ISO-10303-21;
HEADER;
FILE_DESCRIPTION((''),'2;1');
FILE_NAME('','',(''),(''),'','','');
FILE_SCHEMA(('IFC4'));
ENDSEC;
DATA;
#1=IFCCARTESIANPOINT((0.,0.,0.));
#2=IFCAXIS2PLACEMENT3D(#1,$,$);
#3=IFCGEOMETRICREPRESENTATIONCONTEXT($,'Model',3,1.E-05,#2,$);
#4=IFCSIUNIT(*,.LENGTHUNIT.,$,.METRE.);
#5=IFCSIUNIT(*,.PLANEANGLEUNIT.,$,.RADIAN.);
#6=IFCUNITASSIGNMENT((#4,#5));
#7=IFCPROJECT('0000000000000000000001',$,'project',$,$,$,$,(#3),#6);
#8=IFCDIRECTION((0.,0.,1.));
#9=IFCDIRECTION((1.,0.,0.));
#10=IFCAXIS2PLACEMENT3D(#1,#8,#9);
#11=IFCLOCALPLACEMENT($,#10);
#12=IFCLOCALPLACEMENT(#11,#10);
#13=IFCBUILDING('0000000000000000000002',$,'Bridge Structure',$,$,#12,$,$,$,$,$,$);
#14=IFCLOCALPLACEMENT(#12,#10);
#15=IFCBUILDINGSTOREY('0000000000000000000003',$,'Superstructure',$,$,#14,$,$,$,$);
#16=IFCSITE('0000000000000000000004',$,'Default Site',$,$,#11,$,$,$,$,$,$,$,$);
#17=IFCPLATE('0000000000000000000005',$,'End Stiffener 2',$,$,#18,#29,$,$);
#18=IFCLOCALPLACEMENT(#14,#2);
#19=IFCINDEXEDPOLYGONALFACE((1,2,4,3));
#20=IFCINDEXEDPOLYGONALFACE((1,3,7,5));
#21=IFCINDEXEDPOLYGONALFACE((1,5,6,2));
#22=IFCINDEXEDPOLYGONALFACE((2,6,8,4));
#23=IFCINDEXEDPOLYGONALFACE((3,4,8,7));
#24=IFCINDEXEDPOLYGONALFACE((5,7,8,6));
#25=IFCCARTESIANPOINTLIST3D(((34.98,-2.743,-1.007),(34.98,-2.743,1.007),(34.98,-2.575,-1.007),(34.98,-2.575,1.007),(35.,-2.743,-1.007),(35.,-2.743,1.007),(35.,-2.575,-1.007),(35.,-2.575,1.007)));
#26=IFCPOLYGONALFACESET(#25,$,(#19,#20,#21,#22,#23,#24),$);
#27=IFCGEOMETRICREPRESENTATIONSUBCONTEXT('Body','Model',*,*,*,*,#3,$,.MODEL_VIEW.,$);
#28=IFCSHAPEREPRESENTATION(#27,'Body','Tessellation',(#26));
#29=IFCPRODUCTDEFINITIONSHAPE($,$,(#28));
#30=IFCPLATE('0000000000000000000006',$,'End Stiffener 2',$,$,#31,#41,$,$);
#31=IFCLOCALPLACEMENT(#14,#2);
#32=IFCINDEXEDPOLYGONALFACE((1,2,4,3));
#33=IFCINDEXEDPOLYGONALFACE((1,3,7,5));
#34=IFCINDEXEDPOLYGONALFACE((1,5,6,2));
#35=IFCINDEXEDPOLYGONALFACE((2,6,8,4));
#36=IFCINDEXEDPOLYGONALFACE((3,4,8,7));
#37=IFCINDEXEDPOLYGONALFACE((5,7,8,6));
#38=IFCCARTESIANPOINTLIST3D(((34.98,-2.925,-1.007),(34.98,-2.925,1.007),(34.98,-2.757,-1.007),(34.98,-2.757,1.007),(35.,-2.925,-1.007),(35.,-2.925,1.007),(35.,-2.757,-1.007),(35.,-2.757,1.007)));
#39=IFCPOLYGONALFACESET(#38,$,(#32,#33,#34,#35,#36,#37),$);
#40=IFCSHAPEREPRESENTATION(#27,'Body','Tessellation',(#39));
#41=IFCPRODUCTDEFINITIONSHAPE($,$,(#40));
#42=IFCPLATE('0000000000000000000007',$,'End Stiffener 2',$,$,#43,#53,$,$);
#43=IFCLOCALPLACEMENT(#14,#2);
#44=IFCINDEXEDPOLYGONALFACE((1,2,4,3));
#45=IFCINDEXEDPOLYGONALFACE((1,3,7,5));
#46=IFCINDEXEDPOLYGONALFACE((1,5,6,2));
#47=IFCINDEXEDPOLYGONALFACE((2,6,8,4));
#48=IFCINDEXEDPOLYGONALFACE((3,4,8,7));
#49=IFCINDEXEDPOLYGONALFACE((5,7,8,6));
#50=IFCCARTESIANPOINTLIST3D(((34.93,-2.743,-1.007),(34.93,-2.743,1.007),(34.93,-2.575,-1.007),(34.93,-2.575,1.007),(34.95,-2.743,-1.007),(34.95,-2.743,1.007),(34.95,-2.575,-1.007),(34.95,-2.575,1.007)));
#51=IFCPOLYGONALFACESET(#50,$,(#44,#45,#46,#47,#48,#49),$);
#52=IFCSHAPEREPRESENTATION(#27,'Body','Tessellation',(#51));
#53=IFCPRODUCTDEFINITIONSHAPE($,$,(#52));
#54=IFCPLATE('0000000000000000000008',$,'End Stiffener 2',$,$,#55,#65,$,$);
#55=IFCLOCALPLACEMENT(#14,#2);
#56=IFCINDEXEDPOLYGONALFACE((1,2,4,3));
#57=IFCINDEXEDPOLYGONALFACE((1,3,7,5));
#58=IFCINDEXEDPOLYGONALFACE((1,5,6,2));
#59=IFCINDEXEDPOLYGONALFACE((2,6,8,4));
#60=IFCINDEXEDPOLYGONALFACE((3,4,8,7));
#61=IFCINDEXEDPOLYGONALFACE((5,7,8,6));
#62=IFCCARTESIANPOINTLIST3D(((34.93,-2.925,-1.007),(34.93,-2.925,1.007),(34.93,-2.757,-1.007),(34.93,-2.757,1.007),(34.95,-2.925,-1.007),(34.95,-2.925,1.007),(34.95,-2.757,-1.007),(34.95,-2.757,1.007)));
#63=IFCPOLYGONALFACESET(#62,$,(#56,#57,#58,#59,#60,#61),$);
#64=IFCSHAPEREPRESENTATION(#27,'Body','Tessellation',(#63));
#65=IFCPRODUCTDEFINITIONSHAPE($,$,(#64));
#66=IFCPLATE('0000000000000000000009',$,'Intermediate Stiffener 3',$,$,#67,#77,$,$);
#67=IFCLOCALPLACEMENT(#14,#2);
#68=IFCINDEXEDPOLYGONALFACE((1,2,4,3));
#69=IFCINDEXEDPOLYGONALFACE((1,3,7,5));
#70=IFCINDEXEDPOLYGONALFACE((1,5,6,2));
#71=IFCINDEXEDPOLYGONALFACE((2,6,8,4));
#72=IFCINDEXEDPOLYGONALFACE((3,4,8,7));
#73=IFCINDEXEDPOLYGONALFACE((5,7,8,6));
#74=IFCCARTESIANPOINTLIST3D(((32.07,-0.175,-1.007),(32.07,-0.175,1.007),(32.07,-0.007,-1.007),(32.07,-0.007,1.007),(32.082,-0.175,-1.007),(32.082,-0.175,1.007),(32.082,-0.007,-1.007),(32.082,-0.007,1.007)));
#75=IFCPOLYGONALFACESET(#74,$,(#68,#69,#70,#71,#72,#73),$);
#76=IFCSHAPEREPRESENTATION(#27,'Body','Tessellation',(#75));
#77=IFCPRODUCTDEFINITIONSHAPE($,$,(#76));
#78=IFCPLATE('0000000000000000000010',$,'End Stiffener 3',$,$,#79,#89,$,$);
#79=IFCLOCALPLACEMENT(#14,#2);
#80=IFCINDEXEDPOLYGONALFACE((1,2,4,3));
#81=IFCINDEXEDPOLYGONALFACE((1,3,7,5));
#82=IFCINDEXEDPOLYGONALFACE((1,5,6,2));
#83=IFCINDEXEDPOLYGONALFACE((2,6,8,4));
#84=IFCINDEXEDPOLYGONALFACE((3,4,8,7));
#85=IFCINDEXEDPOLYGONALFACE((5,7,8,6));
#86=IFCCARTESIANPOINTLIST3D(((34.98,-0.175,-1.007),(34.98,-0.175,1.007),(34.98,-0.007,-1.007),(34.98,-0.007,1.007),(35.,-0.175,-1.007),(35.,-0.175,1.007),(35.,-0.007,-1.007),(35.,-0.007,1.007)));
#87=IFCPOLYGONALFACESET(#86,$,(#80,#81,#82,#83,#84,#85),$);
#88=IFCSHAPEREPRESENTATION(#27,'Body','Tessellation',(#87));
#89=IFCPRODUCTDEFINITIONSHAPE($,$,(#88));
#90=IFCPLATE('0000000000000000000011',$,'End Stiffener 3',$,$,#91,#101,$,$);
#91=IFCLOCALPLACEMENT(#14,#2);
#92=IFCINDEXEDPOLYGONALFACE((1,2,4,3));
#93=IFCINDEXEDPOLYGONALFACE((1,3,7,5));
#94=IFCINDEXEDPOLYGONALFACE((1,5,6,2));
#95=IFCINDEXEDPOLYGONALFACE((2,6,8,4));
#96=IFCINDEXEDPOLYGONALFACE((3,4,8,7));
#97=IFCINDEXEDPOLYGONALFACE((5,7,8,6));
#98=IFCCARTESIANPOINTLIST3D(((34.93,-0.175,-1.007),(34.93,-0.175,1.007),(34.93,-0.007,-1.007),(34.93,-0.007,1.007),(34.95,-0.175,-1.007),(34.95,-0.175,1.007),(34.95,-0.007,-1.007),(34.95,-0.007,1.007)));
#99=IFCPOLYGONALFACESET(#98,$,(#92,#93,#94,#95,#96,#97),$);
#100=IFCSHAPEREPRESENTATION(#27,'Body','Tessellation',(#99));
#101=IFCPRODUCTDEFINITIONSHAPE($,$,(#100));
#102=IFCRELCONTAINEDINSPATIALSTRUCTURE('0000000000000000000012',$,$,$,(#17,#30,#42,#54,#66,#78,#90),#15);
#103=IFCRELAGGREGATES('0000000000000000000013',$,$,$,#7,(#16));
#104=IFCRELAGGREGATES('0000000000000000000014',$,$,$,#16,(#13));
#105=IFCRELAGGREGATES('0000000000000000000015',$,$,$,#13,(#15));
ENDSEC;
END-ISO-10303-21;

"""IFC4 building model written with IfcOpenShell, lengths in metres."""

from ifc_helpers import new_model, si_unit, frame, origin, origin_with_axes, origin_2d_with_axis, place, context, subcontext, project, spatial, rectangle, extrude, element, save


model = new_model("IFC4")

# Units and contexts
model_context = context("Model", 3, precision=1e-05, world=origin())
body_context = subcontext(model_context, "Body", "Model", "MODEL_VIEW")
ifc_project = project(units=[si_unit("LENGTHUNIT", "METRE"), si_unit("PLANEANGLEUNIT", "RADIAN")], contexts=[model_context])

# Site, building, storey
site_placement = place(None, origin_with_axes())
site = spatial("IfcSite", under=ifc_project, at=site_placement, Name="Default Site")
building_placement = place(site_placement, origin_with_axes())
building = spatial("IfcBuilding", under=site, at=building_placement, Name="Bridge Structure")
storey_placement = place(building_placement, origin_with_axes())
storey = spatial("IfcBuildingStorey", under=building, at=storey_placement, Name="Superstructure")

# Plates
for number, where, z_axis, x_axis, name in (
    (1, (34.99, -2.659, -1.007), (0.0, 0.0, 1.0), (1.0, 0.0, 0.0), "End Stiffener 2"),
    (2, (34.99, -2.841, -1.007), (0.0, 0.0, 1.0), (1.0, 0.0, 0.0), "End Stiffener 2"),
    (3, (34.94, -2.659, -1.007), (0.0, 0.0, 1.0), (1.0, 0.0, 0.0), "End Stiffener 2"),
    (4, (34.94, -2.841, -1.007), (0.0, 0.0, 1.0), (1.0, 0.0, 0.0), "End Stiffener 2"),
):
    element("IfcPlate", number, at=place(storey_placement, frame(where, z_axis=z_axis, x_axis=x_axis)), inside=storey, Name=name, context=body_context, shape_type="SweptSolid", body=[
        extrude(rectangle(XDim=0.02, YDim=0.168, at=origin_2d_with_axis()), origin_with_axes(), (0.0, 0.0, 1.0), 2.014),
    ])
plate_1_placement = place(storey_placement, frame((32.076, -0.091, -1.007), z_axis=(0.0, 0.0, 1.0), x_axis=(1.0, 0.0, 0.0)))
element("IfcPlate", 5, at=plate_1_placement, inside=storey, Name="Intermediate Stiffener 3", context=body_context, shape_type="SweptSolid", body=[
    extrude(rectangle(XDim=0.012, YDim=0.168, at=origin_2d_with_axis()), origin_with_axes(), (0.0, 0.0, 1.0), 2.014),
])
for number, where, z_axis, x_axis, name in (
    (6, (34.99, -0.091, -1.007), (0.0, 0.0, 1.0), (1.0, 0.0, 0.0), "End Stiffener 3"),
    (7, (34.94, -0.091, -1.007), (0.0, 0.0, 1.0), (1.0, 0.0, 0.0), "End Stiffener 3"),
):
    element("IfcPlate", number, at=place(storey_placement, frame(where, z_axis=z_axis, x_axis=x_axis)), inside=storey, Name=name, context=body_context, shape_type="SweptSolid", body=[
        extrude(rectangle(XDim=0.02, YDim=0.168, at=origin_2d_with_axis()), origin_with_axes(), (0.0, 0.0, 1.0), 2.014),
    ])

save(model, "model.ifc")
